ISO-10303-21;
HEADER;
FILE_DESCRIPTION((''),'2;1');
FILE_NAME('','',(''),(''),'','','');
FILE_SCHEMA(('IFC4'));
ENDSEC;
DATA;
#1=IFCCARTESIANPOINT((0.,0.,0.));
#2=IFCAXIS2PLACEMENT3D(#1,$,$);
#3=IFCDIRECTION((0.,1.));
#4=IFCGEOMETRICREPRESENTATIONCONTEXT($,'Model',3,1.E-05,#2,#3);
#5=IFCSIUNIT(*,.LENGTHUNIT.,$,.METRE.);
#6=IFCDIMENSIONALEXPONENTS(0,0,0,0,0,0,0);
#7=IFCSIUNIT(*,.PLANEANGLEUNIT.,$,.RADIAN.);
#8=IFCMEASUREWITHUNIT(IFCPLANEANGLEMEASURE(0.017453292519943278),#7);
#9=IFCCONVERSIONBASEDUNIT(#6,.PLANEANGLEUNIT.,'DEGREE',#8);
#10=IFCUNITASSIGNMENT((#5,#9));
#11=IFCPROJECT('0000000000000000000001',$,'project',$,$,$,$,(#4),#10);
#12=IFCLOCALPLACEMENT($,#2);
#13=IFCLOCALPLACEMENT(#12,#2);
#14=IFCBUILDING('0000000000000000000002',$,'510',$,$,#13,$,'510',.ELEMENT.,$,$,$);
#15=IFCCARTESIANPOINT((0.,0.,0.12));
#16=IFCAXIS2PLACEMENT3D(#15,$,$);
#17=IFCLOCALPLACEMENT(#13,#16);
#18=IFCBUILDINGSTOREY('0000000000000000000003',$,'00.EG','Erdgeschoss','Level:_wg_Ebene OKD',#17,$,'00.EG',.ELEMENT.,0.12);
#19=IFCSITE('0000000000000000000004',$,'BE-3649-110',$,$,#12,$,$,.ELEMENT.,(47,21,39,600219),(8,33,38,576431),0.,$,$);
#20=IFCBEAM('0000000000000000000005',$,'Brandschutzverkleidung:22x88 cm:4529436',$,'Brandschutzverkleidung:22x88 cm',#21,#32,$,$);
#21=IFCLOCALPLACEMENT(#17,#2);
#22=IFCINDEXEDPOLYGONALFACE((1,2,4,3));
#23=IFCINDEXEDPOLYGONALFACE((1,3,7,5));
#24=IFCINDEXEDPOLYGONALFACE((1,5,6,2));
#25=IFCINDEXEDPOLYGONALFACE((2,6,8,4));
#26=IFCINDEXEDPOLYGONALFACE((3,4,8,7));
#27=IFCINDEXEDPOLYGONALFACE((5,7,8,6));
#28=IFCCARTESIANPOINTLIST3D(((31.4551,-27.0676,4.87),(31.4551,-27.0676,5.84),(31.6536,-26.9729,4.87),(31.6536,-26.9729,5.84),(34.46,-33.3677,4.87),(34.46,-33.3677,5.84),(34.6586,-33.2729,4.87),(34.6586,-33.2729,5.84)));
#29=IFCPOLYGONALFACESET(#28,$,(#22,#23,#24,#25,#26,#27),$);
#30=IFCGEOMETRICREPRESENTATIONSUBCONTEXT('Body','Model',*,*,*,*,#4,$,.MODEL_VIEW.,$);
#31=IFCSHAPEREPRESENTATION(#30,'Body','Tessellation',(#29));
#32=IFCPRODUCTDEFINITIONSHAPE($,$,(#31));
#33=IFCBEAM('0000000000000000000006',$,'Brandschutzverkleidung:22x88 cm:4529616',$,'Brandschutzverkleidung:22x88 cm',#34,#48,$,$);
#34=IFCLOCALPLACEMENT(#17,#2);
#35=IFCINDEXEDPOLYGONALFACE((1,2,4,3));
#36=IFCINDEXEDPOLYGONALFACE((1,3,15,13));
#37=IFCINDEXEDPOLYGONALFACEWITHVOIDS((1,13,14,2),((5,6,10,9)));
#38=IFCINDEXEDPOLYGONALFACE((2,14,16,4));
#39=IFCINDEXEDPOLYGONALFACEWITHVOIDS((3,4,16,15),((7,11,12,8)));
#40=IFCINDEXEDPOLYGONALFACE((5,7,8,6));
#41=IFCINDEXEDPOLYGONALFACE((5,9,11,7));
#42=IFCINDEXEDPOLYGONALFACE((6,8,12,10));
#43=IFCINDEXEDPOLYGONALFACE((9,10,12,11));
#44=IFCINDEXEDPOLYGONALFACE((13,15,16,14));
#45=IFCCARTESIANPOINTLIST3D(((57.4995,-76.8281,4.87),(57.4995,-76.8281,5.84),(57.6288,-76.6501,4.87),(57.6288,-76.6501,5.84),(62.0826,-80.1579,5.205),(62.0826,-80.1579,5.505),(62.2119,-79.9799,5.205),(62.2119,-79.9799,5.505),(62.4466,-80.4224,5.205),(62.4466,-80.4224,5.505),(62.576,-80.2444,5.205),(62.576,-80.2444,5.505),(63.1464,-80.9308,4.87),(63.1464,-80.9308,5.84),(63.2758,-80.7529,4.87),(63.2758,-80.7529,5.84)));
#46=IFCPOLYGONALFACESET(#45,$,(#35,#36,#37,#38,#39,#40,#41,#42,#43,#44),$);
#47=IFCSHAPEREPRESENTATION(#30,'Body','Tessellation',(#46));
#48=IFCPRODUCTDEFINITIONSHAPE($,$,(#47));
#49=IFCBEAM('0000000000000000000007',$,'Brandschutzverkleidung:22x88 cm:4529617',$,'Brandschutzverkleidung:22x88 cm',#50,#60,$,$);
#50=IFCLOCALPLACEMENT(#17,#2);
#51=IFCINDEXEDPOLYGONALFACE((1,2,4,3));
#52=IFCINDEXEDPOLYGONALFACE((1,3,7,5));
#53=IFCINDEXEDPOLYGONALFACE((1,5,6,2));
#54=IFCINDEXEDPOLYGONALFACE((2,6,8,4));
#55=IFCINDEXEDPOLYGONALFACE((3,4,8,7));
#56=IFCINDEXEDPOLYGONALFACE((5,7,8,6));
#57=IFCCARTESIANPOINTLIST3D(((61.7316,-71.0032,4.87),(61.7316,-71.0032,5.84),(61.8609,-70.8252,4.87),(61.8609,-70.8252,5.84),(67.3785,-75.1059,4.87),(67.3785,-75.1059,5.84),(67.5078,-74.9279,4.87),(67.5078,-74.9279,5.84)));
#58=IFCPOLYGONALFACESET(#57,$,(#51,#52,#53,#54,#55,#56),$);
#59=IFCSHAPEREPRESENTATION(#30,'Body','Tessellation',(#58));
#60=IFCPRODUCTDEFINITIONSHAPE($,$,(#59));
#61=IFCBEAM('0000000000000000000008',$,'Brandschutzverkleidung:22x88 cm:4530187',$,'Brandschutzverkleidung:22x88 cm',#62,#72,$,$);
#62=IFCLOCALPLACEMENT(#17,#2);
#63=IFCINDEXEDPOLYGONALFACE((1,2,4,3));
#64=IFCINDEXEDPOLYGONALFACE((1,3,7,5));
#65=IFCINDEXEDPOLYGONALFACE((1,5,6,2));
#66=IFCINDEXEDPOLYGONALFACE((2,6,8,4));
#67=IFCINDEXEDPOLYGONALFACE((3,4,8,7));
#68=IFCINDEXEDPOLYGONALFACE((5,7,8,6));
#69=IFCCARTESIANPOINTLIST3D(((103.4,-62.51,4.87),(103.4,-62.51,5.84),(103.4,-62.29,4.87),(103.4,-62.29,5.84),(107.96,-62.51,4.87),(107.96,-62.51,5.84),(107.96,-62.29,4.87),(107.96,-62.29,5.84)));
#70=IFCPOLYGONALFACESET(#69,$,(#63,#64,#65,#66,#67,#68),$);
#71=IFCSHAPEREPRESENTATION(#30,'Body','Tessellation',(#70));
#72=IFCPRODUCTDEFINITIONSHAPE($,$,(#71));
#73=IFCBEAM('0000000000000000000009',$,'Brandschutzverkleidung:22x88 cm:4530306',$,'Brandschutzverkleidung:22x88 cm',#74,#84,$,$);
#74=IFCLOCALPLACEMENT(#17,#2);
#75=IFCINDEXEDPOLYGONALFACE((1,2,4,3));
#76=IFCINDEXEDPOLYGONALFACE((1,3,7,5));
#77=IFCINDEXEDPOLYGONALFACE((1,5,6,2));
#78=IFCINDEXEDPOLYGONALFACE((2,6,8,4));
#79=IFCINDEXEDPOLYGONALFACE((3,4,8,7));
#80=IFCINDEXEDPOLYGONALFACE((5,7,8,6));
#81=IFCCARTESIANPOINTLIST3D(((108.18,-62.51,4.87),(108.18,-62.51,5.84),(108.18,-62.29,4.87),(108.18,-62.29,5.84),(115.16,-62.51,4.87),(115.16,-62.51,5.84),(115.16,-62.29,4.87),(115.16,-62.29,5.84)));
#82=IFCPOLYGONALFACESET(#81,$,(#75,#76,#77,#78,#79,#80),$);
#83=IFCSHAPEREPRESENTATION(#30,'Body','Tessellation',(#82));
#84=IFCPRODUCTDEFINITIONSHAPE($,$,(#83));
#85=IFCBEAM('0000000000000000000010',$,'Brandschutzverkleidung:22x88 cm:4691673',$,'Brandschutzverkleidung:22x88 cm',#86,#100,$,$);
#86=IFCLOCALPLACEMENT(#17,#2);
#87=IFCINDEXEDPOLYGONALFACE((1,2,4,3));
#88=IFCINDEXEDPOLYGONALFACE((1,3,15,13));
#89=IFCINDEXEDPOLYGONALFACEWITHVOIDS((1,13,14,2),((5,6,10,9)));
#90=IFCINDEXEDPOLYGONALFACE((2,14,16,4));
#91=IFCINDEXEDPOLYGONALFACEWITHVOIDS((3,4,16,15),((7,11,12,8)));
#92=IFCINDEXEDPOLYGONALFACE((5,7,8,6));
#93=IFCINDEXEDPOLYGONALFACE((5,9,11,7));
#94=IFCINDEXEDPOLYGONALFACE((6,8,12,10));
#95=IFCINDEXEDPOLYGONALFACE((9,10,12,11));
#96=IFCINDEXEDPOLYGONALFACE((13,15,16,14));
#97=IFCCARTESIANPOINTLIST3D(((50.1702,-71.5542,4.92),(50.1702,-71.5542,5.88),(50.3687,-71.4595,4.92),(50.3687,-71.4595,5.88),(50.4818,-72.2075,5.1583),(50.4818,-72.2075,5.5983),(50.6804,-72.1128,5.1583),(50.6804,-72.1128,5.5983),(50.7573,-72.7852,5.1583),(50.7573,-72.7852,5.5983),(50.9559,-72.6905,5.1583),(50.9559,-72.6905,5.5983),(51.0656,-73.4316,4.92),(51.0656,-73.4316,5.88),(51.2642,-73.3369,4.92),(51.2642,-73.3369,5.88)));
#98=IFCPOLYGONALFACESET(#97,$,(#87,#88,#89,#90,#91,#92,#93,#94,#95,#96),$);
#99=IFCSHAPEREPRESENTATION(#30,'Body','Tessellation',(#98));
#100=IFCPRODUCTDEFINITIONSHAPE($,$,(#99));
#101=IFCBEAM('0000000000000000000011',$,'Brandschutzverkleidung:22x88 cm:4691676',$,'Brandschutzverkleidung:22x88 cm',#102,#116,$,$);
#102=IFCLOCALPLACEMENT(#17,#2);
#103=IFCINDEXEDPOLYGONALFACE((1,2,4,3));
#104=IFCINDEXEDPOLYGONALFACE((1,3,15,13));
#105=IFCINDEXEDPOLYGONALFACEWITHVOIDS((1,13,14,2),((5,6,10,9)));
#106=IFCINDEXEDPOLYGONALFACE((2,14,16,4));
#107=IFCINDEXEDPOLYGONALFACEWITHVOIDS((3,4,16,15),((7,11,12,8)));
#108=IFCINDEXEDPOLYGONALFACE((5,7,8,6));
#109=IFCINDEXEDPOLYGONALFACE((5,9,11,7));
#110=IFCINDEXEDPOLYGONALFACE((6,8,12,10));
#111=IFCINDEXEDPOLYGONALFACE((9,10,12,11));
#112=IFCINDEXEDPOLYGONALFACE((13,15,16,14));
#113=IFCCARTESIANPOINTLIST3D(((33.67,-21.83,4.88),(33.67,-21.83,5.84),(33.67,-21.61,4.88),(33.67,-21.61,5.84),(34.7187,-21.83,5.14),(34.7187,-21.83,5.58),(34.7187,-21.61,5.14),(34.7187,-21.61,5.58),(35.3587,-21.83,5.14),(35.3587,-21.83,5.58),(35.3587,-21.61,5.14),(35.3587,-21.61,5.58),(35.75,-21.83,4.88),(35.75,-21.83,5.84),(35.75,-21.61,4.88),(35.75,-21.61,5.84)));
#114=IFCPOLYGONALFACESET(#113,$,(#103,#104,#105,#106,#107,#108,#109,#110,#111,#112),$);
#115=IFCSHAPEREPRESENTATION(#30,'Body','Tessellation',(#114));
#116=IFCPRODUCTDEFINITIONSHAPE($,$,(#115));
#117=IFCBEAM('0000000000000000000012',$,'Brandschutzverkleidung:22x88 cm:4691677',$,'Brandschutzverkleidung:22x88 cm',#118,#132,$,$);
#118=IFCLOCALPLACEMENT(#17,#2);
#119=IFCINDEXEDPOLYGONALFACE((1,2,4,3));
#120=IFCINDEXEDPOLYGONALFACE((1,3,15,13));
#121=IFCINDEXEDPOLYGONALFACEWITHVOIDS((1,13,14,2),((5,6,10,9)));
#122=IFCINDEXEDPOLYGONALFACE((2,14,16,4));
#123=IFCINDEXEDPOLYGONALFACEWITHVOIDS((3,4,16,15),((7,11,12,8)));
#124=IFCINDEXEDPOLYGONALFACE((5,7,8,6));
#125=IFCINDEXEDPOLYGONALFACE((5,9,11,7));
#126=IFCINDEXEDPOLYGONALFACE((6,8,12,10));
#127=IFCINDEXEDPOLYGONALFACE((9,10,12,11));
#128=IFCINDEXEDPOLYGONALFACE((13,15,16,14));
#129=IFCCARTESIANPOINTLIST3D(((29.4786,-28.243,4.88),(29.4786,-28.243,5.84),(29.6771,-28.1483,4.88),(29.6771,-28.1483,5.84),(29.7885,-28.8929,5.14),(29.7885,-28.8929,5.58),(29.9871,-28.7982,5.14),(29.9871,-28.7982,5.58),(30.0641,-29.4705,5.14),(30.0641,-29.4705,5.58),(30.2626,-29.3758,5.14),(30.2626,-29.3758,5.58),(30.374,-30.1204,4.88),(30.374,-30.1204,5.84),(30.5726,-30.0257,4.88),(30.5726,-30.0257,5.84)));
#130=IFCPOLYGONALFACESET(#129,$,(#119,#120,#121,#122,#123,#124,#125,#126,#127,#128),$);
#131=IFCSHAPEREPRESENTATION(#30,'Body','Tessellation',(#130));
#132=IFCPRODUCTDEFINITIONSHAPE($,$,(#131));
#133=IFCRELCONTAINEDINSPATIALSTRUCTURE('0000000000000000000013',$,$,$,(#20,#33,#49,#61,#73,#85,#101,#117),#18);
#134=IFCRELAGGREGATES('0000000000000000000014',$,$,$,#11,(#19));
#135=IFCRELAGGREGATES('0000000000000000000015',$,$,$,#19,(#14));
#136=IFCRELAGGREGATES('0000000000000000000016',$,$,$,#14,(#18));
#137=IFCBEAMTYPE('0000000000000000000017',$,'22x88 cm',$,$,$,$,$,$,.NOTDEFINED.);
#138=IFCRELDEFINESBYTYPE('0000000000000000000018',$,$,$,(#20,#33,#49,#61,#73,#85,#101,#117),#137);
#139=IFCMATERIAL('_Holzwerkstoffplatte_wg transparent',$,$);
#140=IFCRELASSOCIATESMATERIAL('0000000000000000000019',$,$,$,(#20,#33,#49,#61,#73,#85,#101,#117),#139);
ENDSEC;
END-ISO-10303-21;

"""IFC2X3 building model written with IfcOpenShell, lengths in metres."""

from ifc_helpers import new_model, entity, si_unit, converted_unit, direction, frame, frame_2d, origin, origin_2d_with_axis, place, context, subcontext, project, spatial, polyline, rectangle, outline, extrude, material, type_object, element, save


model = new_model("IFC2X3")

# Units and contexts
model_context = context("Model", 3, precision=1e-05, world=origin(), true_north=direction((0.0, 1.0)))
body_context = subcontext(model_context, "Body", "Model", "MODEL_VIEW")
ifc_project = project(units=[si_unit("LENGTHUNIT", "METRE"), converted_unit("PLANEANGLEUNIT", "DEGREE", entity("IfcPlaneAngleMeasure", 0.017453292519943278), si_unit("PLANEANGLEUNIT", "RADIAN"), dimensions=[0, 0, 0, 0, 0, 0, 0])], contexts=[model_context])

# Site, building, storey
site_placement = place(None, origin())
site = spatial("IfcSite", under=ifc_project, at=site_placement, Name="BE-3649-110", CompositionType="ELEMENT", RefLatitude=(47, 21, 39, 600219), RefLongitude=(8, 33, 38, 576431), RefElevation=0.0)
building_placement = place(site_placement, origin())
building = spatial("IfcBuilding", under=site, at=building_placement, Name="510", LongName="510", CompositionType="ELEMENT")
storey_placement = place(building_placement, frame((0.0, 0.0, 0.12)))
storey = spatial("IfcBuildingStorey", under=building, at=storey_placement, Name="00.EG", Description="Erdgeschoss", ObjectType="Level:_wg_Ebene OKD", LongName="00.EG", CompositionType="ELEMENT", Elevation=0.12)

# Beams
ifc_material_1 = material(Name="_Holzwerkstoffplatte_wg transparent")
beam_type_1 = type_object("IfcBeamType", Name="22x88 cm", PredefinedType="NOTDEFINED")
beam_1_placement = place(storey_placement, frame((0.0, 0.0, 5.355)))
element("IfcBeam", 1, at=beam_1_placement, inside=storey, type_object=beam_type_1, material=ifc_material_1, Name="Brandschutzverkleidung:22x88 cm:4529436", ObjectType="Brandschutzverkleidung:22x88 cm", context=body_context, shape_type="SweptSolid", body=[
    extrude(rectangle(XDim=0.97, YDim=0.22, at=frame_2d((0.0, 0.0), x_axis=(0.0, 1.0))), frame((34.5593, -33.3203, 0.0), z_axis=(-0.430511, 0.902585, 0.0), x_axis=(0.902585, 0.430511, 0.0)), (0.0, 0.0, 1.0), 6.98),
])
beam_2_placement = place(storey_placement, frame((0.0, 0.0, 5.355)))
element("IfcBeam", 2, at=beam_2_placement, inside=storey, type_object=beam_type_1, material=ifc_material_1, Name="Brandschutzverkleidung:22x88 cm:4529616", ObjectType="Brandschutzverkleidung:22x88 cm", context=body_context, shape_type="SweptSolid", body=[
    extrude(outline(polyline([(-3.49, -0.485), (3.49, -0.485), (3.49, 0.485), (-3.49, 0.485), (-3.49, -0.485)]), holes=[polyline([(2.175, -0.15), (2.175, 0.15), (2.625, 0.15), (2.625, -0.15), (2.175, -0.15)])]), frame((60.323, -78.8795, 0.0), z_axis=(0.587785, 0.809017, 0.0), x_axis=(0.809017, -0.587785, 0.0)), (0.0, 0.0, 1.0), 0.22),
])
beam_3_placement = place(storey_placement, frame((0.0, 0.0, 5.355)))
element("IfcBeam", 3, at=beam_3_placement, inside=storey, type_object=beam_type_1, material=ifc_material_1, Name="Brandschutzverkleidung:22x88 cm:4529617", ObjectType="Brandschutzverkleidung:22x88 cm", context=body_context, shape_type="SweptSolid", body=[
    extrude(rectangle(XDim=0.97, YDim=0.22, at=origin_2d_with_axis()), frame((61.7962, -70.9142, 0.0), z_axis=(0.809017, -0.587785, 0.0), x_axis=(0.0, 0.0, -1.0)), (0.0, 0.0, 1.0), 6.98),
])
beam_4_placement = place(storey_placement, frame((0.0, 0.0, 5.355)))
element("IfcBeam", 4, at=beam_4_placement, inside=storey, type_object=beam_type_1, material=ifc_material_1, Name="Brandschutzverkleidung:22x88 cm:4530187", ObjectType="Brandschutzverkleidung:22x88 cm", context=body_context, shape_type="SweptSolid", body=[
    extrude(rectangle(XDim=0.97, YDim=0.22, at=origin_2d_with_axis()), frame((103.4, -62.4, 0.0), z_axis=(1.0, 0.0, 0.0), x_axis=(0.0, 0.0, -1.0)), (0.0, 0.0, 1.0), 4.56),
])
beam_5_placement = place(storey_placement, frame((0.0, 0.0, 5.355)))
element("IfcBeam", 5, at=beam_5_placement, inside=storey, type_object=beam_type_1, material=ifc_material_1, Name="Brandschutzverkleidung:22x88 cm:4530306", ObjectType="Brandschutzverkleidung:22x88 cm", context=body_context, shape_type="SweptSolid", body=[
    extrude(rectangle(XDim=0.97, YDim=0.22, at=origin_2d_with_axis()), frame((108.18, -62.4, 0.0), z_axis=(1.0, 0.0, 0.0), x_axis=(0.0, 0.0, -1.0)), (0.0, 0.0, 1.0), 6.98),
])
beam_6_placement = place(storey_placement, frame((0.0, 0.0, 5.4)))
element("IfcBeam", 6, at=beam_6_placement, inside=storey, type_object=beam_type_1, material=ifc_material_1, Name="Brandschutzverkleidung:22x88 cm:4691673", ObjectType="Brandschutzverkleidung:22x88 cm", context=body_context, shape_type="SweptSolid", body=[
    extrude(outline(polyline([(-1.04, -0.48), (1.04, -0.48), (1.04, 0.48), (-1.04, 0.48), (-1.04, -0.48)]), holes=[polyline([(0.3238, 0.2417), (0.3238, -0.1983), (-0.3162, -0.1983), (-0.3162, 0.2417), (0.3238, 0.2417)])]), frame((50.6179, -72.4929, 0.0), z_axis=(0.902585, 0.430511, 0.0), x_axis=(0.430511, -0.902585, 0.0)), (0.0, 0.0, 1.0), 0.22),
])
beam_7_placement = place(storey_placement, frame((0.0, 0.0, 5.36)))
element("IfcBeam", 7, at=beam_7_placement, inside=storey, type_object=beam_type_1, material=ifc_material_1, Name="Brandschutzverkleidung:22x88 cm:4691676", ObjectType="Brandschutzverkleidung:22x88 cm", context=body_context, shape_type="SweptSolid", body=[
    extrude(outline(polyline([(-1.04, -0.48), (1.04, -0.48), (1.04, 0.48), (-1.04, 0.48), (-1.04, -0.48)]), holes=[polyline([(0.6487, 0.22), (0.6487, -0.22), (0.0087, -0.22), (0.0087, 0.22), (0.6487, 0.22)])]), frame((34.71, -21.83, 0.0), z_axis=(0.0, 1.0, 0.0), x_axis=(1.0, 0.0, 0.0)), (0.0, 0.0, 1.0), 0.22),
])
beam_8_placement = place(storey_placement, frame((0.0, 0.0, 5.36)))
element("IfcBeam", 8, at=beam_8_placement, inside=storey, type_object=beam_type_1, material=ifc_material_1, Name="Brandschutzverkleidung:22x88 cm:4691677", ObjectType="Brandschutzverkleidung:22x88 cm", context=body_context, shape_type="SweptSolid", body=[
    extrude(outline(polyline([(-1.04, -0.48), (1.04, -0.48), (1.04, 0.48), (-1.04, 0.48), (-1.04, -0.48)]), holes=[polyline([(-0.32, -0.22), (-0.32, 0.22), (0.32, 0.22), (0.32, -0.22), (-0.32, -0.22)])]), frame((29.9263, -29.1817, 0.0), z_axis=(0.902585, 0.430511, 0.0), x_axis=(-0.430511, 0.902585, 0.0)), (0.0, 0.0, 1.0), 0.22),
])

save(model, "model.ifc")
